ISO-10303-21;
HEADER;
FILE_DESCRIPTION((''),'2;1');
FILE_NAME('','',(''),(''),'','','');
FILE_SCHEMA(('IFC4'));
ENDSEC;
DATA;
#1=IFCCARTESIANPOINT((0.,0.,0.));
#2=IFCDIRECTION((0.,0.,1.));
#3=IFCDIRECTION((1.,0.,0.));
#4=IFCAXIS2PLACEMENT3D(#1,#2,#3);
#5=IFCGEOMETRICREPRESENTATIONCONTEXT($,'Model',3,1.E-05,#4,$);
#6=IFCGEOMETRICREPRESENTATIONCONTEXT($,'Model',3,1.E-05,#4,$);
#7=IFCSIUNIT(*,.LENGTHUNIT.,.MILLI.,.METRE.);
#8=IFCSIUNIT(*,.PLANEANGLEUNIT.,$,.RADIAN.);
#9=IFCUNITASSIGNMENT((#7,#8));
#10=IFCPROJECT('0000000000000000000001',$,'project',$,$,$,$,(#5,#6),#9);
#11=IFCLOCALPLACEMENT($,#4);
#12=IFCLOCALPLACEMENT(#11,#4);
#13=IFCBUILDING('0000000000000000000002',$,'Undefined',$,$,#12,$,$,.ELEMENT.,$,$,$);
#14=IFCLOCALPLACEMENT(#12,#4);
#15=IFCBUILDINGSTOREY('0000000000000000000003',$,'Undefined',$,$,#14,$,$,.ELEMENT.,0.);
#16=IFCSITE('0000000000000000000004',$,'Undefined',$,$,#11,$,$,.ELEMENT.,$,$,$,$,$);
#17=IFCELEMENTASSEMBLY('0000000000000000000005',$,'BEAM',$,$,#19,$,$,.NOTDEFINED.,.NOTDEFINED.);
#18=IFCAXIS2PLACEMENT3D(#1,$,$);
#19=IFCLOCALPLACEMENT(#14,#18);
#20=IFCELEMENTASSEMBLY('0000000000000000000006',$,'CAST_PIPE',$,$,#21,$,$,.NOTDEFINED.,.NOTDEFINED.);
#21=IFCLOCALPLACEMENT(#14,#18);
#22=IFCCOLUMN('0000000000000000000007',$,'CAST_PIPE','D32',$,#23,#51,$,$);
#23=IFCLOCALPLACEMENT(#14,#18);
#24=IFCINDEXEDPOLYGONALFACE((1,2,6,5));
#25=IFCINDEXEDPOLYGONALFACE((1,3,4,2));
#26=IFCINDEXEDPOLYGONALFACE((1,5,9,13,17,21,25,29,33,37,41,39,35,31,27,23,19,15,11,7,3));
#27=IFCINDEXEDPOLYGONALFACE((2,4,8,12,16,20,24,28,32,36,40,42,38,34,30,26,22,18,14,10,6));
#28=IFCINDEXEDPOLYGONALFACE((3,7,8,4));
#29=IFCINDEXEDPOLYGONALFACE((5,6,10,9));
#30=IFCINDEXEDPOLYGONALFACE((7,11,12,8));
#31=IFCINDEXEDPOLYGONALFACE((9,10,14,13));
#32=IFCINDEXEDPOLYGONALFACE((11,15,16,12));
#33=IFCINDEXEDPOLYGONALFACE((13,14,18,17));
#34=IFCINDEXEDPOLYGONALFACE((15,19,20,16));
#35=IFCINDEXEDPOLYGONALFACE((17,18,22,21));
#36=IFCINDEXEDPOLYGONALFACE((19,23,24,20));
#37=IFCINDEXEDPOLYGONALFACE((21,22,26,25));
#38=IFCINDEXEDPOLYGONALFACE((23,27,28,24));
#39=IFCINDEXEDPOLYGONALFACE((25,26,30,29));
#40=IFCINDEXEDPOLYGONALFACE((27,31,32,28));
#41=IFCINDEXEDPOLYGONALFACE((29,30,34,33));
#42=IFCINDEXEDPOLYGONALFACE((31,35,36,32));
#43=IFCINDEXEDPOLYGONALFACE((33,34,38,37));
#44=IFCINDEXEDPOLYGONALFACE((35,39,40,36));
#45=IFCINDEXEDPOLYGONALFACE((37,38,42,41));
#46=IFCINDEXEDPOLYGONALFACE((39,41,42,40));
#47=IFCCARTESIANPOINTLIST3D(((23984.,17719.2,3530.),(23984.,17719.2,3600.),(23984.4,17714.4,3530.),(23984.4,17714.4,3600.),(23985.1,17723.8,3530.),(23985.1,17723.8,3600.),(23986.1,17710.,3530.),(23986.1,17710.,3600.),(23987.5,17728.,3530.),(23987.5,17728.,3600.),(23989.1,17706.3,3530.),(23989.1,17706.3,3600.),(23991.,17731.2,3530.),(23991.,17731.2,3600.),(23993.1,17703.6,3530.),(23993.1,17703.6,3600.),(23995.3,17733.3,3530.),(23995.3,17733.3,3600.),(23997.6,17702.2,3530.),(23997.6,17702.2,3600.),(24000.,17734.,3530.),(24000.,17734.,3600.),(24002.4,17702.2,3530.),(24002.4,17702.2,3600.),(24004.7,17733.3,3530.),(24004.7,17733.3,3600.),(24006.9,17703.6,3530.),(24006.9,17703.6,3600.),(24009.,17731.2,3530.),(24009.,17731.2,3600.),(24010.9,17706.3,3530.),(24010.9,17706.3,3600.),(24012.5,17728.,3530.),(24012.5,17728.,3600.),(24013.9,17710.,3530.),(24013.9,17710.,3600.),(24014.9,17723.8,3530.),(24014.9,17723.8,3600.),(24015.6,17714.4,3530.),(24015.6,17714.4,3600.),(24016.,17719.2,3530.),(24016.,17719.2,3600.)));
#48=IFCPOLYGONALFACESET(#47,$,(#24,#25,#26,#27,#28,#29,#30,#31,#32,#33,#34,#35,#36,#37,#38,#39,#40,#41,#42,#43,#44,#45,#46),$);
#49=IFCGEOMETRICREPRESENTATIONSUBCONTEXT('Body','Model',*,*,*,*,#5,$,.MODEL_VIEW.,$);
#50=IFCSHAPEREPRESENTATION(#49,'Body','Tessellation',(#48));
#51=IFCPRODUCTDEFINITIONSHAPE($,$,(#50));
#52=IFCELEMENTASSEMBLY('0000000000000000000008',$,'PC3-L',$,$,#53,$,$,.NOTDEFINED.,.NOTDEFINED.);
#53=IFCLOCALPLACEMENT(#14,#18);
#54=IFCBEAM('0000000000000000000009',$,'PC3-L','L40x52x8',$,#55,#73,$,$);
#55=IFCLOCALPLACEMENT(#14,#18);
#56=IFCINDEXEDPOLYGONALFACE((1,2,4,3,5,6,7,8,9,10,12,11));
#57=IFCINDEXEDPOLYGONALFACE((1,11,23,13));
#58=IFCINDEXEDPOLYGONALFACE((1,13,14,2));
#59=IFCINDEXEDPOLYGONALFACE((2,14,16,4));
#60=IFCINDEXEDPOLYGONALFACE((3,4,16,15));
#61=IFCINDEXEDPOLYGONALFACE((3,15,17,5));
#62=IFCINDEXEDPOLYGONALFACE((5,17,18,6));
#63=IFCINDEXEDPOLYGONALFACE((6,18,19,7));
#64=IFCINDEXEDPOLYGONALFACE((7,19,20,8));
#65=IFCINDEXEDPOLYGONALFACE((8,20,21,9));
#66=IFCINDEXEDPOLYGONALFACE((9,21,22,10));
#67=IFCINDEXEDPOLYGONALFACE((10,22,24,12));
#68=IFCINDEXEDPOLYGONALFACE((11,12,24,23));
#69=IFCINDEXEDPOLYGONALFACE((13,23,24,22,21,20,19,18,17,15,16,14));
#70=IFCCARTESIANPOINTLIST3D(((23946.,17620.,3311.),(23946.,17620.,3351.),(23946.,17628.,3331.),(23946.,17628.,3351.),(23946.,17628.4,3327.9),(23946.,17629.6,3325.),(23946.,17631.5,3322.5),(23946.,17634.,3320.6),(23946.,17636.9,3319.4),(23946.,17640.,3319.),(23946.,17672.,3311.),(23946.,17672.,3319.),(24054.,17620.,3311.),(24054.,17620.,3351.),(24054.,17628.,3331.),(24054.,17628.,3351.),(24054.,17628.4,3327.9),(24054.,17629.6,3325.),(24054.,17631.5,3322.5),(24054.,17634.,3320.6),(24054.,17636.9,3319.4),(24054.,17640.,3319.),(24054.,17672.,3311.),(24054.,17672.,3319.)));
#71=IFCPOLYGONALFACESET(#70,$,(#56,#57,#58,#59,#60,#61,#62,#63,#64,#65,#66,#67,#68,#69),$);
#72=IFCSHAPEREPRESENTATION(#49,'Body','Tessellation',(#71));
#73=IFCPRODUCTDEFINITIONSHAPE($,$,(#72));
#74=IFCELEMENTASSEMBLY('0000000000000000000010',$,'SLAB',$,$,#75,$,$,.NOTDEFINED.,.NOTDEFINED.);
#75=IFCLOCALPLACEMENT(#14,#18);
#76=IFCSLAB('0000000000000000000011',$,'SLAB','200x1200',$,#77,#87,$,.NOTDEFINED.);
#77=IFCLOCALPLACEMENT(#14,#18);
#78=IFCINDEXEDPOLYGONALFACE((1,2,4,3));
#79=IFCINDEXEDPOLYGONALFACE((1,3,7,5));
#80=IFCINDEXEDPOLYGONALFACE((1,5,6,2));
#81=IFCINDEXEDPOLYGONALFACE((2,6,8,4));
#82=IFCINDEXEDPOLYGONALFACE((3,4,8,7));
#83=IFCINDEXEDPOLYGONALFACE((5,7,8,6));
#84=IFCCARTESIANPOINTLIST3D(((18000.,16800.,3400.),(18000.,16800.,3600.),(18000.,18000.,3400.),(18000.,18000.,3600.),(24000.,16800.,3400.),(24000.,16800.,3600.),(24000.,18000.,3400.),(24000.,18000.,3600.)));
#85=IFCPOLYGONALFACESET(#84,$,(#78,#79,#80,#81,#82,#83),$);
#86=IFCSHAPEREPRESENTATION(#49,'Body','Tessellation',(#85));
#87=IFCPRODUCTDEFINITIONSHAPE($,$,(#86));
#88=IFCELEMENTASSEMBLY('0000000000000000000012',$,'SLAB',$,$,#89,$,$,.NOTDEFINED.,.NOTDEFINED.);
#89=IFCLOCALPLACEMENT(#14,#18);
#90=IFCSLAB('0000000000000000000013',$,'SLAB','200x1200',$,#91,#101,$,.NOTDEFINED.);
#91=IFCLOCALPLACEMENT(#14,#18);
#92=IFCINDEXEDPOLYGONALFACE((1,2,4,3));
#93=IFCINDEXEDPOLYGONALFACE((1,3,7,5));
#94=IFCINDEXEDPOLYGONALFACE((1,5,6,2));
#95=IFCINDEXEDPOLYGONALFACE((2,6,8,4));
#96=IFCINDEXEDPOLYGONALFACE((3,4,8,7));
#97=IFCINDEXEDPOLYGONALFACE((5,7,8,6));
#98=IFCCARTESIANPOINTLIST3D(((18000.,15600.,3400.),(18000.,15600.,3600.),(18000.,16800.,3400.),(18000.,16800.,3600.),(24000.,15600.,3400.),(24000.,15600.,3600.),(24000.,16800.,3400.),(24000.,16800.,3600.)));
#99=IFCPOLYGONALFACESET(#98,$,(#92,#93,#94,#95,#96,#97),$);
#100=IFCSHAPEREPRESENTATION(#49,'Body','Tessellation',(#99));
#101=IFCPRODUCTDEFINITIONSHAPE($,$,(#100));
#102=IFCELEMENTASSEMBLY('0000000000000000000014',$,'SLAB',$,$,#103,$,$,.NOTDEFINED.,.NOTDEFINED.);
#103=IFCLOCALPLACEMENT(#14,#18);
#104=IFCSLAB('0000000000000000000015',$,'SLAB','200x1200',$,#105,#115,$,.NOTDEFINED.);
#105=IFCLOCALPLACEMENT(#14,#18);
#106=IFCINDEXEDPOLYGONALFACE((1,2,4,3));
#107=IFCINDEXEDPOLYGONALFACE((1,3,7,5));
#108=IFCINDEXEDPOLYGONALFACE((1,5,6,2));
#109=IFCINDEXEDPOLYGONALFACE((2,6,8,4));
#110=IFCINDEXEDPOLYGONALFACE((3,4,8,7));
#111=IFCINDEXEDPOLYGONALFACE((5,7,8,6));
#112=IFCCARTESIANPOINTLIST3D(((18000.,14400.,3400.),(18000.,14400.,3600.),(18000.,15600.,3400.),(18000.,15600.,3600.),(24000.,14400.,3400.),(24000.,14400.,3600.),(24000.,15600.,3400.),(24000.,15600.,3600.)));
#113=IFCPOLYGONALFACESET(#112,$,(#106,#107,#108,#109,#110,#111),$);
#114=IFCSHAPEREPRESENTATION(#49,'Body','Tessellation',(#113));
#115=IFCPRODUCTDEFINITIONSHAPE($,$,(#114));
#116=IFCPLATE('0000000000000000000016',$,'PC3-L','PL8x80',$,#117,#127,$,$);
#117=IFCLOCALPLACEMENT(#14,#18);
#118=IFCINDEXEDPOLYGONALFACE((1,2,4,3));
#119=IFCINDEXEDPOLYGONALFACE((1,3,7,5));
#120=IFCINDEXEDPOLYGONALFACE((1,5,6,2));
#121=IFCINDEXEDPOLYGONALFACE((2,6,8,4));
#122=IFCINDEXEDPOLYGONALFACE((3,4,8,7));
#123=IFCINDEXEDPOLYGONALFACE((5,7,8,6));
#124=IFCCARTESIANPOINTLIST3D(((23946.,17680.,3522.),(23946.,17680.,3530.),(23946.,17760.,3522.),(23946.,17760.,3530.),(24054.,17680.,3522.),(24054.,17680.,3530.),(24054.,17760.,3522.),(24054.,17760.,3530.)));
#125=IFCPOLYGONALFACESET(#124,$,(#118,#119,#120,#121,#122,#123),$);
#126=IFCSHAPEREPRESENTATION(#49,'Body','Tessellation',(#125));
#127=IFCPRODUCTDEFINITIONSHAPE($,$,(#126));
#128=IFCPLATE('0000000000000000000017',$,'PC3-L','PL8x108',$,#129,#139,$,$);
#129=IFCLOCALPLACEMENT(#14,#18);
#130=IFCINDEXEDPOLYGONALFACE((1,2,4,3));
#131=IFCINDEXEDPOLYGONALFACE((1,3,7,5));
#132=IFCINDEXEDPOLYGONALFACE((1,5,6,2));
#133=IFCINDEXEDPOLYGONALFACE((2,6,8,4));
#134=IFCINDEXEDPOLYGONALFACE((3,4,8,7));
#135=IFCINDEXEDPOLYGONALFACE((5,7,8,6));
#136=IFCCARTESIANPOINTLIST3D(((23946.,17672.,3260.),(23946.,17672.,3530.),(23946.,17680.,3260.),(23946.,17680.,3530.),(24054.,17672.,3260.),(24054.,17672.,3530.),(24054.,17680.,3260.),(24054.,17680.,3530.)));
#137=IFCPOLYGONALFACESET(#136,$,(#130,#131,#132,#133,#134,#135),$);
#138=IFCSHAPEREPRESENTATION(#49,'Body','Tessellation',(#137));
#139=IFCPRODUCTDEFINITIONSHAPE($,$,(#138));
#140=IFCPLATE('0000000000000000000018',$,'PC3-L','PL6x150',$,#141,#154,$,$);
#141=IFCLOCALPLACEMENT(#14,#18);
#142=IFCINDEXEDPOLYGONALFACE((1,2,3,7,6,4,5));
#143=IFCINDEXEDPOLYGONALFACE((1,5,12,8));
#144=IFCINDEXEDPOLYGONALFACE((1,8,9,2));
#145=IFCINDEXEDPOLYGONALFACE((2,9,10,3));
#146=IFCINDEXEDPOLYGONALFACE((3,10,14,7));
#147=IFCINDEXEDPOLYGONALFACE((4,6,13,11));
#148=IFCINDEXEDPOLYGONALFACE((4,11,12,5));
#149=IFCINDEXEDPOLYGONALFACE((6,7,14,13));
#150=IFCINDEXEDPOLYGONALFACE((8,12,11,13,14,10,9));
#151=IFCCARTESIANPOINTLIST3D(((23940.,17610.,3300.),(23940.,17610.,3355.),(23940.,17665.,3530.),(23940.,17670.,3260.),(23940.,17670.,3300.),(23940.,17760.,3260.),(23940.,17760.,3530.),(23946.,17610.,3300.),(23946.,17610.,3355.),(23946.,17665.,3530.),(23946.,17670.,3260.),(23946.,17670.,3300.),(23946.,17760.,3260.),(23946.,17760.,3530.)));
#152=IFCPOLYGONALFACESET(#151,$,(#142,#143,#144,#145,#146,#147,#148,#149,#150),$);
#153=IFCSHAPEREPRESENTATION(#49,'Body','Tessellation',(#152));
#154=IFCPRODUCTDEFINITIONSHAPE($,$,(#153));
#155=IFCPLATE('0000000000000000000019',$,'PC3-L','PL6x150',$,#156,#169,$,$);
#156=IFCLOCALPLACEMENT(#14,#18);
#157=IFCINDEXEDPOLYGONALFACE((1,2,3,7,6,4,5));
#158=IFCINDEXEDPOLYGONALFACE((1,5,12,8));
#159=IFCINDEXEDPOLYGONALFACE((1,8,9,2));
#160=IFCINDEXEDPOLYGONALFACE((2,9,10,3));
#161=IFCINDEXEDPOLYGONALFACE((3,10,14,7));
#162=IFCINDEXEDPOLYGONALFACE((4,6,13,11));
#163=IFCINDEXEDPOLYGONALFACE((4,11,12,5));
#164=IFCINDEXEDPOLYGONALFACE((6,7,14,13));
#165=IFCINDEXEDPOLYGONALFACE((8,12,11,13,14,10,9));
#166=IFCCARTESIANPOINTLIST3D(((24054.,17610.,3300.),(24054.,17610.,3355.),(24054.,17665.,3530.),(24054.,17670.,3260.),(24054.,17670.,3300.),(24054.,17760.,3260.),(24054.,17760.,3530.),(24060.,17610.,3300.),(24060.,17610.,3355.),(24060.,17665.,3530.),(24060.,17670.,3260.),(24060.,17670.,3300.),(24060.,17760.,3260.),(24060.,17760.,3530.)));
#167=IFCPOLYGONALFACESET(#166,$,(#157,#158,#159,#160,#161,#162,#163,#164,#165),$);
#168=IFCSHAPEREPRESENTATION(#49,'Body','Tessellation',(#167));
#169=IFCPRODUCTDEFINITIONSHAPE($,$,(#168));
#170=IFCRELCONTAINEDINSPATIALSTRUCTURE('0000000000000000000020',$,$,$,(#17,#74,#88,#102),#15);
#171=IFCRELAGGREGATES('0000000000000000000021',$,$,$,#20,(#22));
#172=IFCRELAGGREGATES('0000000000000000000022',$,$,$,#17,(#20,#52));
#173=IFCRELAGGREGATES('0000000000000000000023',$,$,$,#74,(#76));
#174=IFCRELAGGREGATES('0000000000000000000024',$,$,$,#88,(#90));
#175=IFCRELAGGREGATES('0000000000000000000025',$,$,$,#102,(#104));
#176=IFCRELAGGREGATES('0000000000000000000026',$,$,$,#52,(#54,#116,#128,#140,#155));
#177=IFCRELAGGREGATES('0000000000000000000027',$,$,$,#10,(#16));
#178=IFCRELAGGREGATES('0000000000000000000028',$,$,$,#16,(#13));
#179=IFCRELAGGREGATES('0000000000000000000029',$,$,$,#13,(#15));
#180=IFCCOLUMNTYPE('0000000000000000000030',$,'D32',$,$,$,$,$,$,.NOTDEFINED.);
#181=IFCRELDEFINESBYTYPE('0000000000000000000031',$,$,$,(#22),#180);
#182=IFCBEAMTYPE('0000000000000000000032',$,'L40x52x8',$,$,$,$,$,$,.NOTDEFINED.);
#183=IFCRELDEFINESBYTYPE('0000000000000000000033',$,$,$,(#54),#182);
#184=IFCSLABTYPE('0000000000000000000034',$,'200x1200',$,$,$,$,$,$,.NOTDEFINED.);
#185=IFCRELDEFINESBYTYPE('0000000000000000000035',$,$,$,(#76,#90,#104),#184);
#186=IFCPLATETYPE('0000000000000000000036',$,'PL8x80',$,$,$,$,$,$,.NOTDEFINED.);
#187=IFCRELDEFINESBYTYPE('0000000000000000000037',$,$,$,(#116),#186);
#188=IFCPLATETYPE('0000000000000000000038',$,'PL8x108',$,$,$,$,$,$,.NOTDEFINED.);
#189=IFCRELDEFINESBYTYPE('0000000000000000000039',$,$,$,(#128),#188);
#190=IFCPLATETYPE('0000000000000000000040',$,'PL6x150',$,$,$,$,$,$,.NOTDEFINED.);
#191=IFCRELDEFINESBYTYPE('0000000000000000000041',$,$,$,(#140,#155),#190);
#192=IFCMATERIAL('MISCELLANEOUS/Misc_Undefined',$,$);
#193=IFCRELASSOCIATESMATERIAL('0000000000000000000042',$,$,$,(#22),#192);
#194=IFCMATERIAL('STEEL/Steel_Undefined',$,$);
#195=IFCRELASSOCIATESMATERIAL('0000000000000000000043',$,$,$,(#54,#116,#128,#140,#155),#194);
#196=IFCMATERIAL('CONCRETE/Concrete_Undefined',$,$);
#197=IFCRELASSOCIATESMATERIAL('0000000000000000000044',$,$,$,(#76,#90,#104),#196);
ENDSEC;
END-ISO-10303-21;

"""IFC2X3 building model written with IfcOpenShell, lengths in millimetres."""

from ifc_helpers import new_model, si_unit, frame, origin_with_axes, origin_2d_with_axis, place, context, subcontext, project, spatial, polyline, circle, l_section, outline, extrude, material, type_object, element, aggregate, save


model = new_model("IFC2X3")

# Units and contexts
model_context_1 = context("Model", 3, precision=1e-05, world=origin_with_axes())
model_context_2 = context("Model", 3, precision=1e-05, world=origin_with_axes())
body_context = subcontext(model_context_1, "Body", "Model", "MODEL_VIEW")
ifc_project = project(units=[si_unit("LENGTHUNIT", "METRE", prefix="MILLI"), si_unit("PLANEANGLEUNIT", "RADIAN")], contexts=[model_context_1, model_context_2])

# Site, building, storey
site_placement = place(None, origin_with_axes())
site = spatial("IfcSite", under=ifc_project, at=site_placement, Name="Undefined", CompositionType="ELEMENT")
building_placement = place(site_placement, origin_with_axes())
building = spatial("IfcBuilding", under=site, at=building_placement, Name="Undefined", CompositionType="ELEMENT")
storey_placement = place(building_placement, origin_with_axes())
storey = spatial("IfcBuildingStorey", under=building, at=storey_placement, Name="Undefined", CompositionType="ELEMENT", Elevation=0.0)

# Element assemblies, column, beam
assembly_1_placement = place(storey_placement, origin_with_axes())
assembly_1 = element("IfcElementAssembly", 1, at=assembly_1_placement, inside=storey, Name="BEAM", AssemblyPlace="NOTDEFINED", PredefinedType="NOTDEFINED")
assembly_2_placement = place(assembly_1_placement, origin_with_axes())
assembly_2 = element("IfcElementAssembly", 2, at=assembly_2_placement, Name="CAST_PIPE", AssemblyPlace="NOTDEFINED", PredefinedType="NOTDEFINED")
ifc_material_1 = material(Name="MISCELLANEOUS/Misc_Undefined")
column_type = type_object("IfcColumnType", Name="D32", PredefinedType="NOTDEFINED")
column_placement = place(assembly_2_placement, frame((24000.0, 17718.0, 3530.0), z_axis=(0.0, 0.0, 1.0), x_axis=(1.0, 0.0, 0.0)))
column = element("IfcColumn", 3, at=column_placement, type_object=column_type, material=ifc_material_1, Name="CAST_PIPE", Description="D32", context=body_context, shape_type="SweptSolid", body=[
    extrude(circle(Radius=16.0, at=origin_2d_with_axis()), frame((0.0, 0.0, 70.0), z_axis=(0.0, 0.0, -1.0), x_axis=(0.0, 1.0, 0.0)), (0.0, 0.0, 1.0), 70.0),
])
aggregate(assembly_2, [column])
assembly_3_placement = place(assembly_1_placement, origin_with_axes())
assembly_3 = element("IfcElementAssembly", 4, at=assembly_3_placement, Name="PC3-L", AssemblyPlace="NOTDEFINED", PredefinedType="NOTDEFINED")
aggregate(assembly_1, [assembly_2, assembly_3])
ifc_material_2 = material(Name="STEEL/Steel_Undefined")
beam_type = type_object("IfcBeamType", Name="L40x52x8", PredefinedType="NOTDEFINED")
beam_placement = place(assembly_3_placement, frame((24054.0, 17646.0, 3331.0), z_axis=(0.0, 0.0, 1.0), x_axis=(-1.0, 0.0, 0.0)))
beam = element("IfcBeam", 5, at=beam_placement, type_object=beam_type, material=ifc_material_2, Name="PC3-L", Description="L40x52x8", context=body_context, shape_type="SweptSolid", body=[
    extrude(l_section(Depth=40.0, Width=52.0, Thickness=8.0, FilletRadius=12.0, at=origin_2d_with_axis()), frame((108.0, 0.0, 0.0), z_axis=(-1.0, 0.0, 0.0), x_axis=(0.0, -1.0, 0.0)), (0.0, 0.0, 1.0), 108.0),
])

# Element assemblies, slabs
assembly_4_placement = place(storey_placement, origin_with_axes())
assembly_4 = element("IfcElementAssembly", 6, at=assembly_4_placement, inside=storey, Name="SLAB", AssemblyPlace="NOTDEFINED", PredefinedType="NOTDEFINED")
ifc_material_3 = material(Name="CONCRETE/Concrete_Undefined")
slab_type = type_object("IfcSlabType", Name="200x1200", PredefinedType="NOTDEFINED")
slab_1_placement = place(assembly_4_placement, frame((24000.0, 16800.0, 3500.0), z_axis=(0.0, 0.0, 1.0), x_axis=(0.0, 1.0, 0.0)))
slab_1 = element("IfcSlab", 7, at=slab_1_placement, type_object=slab_type, material=ifc_material_3, Name="SLAB", Description="200x1200", PredefinedType="NOTDEFINED", context=body_context, shape_type="SweptSolid", body=[
    extrude(outline(polyline([(0.0, 0.0), (1200.0, 0.0), (1200.0, 6000.0), (0.0, 6000.0), (0.0, 0.0)])), frame((0.0, 0.0, -100.0), z_axis=(0.0, 0.0, 1.0), x_axis=(1.0, 0.0, 0.0)), (0.0, 0.0, 1.0), 200.0),
])
aggregate(assembly_4, [slab_1])
assembly_5_placement = place(storey_placement, origin_with_axes())
assembly_5 = element("IfcElementAssembly", 8, at=assembly_5_placement, inside=storey, Name="SLAB", AssemblyPlace="NOTDEFINED", PredefinedType="NOTDEFINED")
slab_2_placement = place(assembly_5_placement, frame((24000.0, 15600.0, 3500.0), z_axis=(0.0, 0.0, 1.0), x_axis=(0.0, 1.0, 0.0)))
slab_2 = element("IfcSlab", 9, at=slab_2_placement, type_object=slab_type, material=ifc_material_3, Name="SLAB", Description="200x1200", PredefinedType="NOTDEFINED", context=body_context, shape_type="SweptSolid", body=[
    extrude(outline(polyline([(0.0, 0.0), (1200.0, 0.0), (1200.0, 6000.0), (0.0, 6000.0), (0.0, 0.0)])), frame((0.0, 0.0, -100.0), z_axis=(0.0, 0.0, 1.0), x_axis=(1.0, 0.0, 0.0)), (0.0, 0.0, 1.0), 200.0),
])
aggregate(assembly_5, [slab_2])
assembly_6_placement = place(storey_placement, origin_with_axes())
assembly_6 = element("IfcElementAssembly", 10, at=assembly_6_placement, inside=storey, Name="SLAB", AssemblyPlace="NOTDEFINED", PredefinedType="NOTDEFINED")
slab_3_placement = place(assembly_6_placement, frame((24000.0, 14400.0, 3500.0), z_axis=(0.0, 0.0, 1.0), x_axis=(0.0, 1.0, 0.0)))
slab_3 = element("IfcSlab", 11, at=slab_3_placement, type_object=slab_type, material=ifc_material_3, Name="SLAB", Description="200x1200", PredefinedType="NOTDEFINED", context=body_context, shape_type="SweptSolid", body=[
    extrude(outline(polyline([(0.0, 0.0), (1200.0, 0.0), (1200.0, 6000.0), (0.0, 6000.0), (0.0, 0.0)])), frame((0.0, 0.0, -100.0), z_axis=(0.0, 0.0, 1.0), x_axis=(1.0, 0.0, 0.0)), (0.0, 0.0, 1.0), 200.0),
])
aggregate(assembly_6, [slab_3])

# Plates
plate_type_1 = type_object("IfcPlateType", Name="PL8x80", PredefinedType="NOTDEFINED")
plate_1_placement = place(assembly_3_placement, frame((24054.0, 17760.0, 3526.0), z_axis=(0.0, 0.0, 1.0), x_axis=(-1.0, 0.0, 0.0)))
plate_1 = element("IfcPlate", 12, at=plate_1_placement, type_object=plate_type_1, material=ifc_material_2, Name="PC3-L", Description="PL8x80", context=body_context, shape_type="SweptSolid", body=[
    extrude(outline(polyline([(0.0, 0.0), (108.0, 0.0), (108.0, 80.0), (0.0, 80.0), (0.0, 0.0)])), frame((0.0, 0.0, -4.0), z_axis=(0.0, 0.0, 1.0), x_axis=(1.0, 0.0, 0.0)), (0.0, 0.0, 1.0), 8.0),
])
plate_type_2 = type_object("IfcPlateType", Name="PL8x108", PredefinedType="NOTDEFINED")
plate_2_placement = place(assembly_3_placement, frame((24054.0, 17676.0, 3260.0), z_axis=(0.0, 1.0, 0.0), x_axis=(-1.0, 0.0, 0.0)))
plate_2 = element("IfcPlate", 13, at=plate_2_placement, type_object=plate_type_2, material=ifc_material_2, Name="PC3-L", Description="PL8x108", context=body_context, shape_type="SweptSolid", body=[
    extrude(outline(polyline([(0.0, 0.0), (108.0, 0.0), (108.0, 270.0), (0.0, 270.0), (0.0, 0.0)])), frame((0.0, 0.0, -4.0), z_axis=(0.0, 0.0, 1.0), x_axis=(1.0, 0.0, 0.0)), (0.0, 0.0, 1.0), 8.0),
])
plate_type_3 = type_object("IfcPlateType", Name="PL6x150", PredefinedType="NOTDEFINED")
plate_3_placement = place(assembly_3_placement, frame((23943.0, 17670.0, 3260.0), z_axis=(-1.0, 0.0, 0.0), x_axis=(0.0, 0.0, 1.0)))
plate_3 = element("IfcPlate", 14, at=plate_3_placement, type_object=plate_type_3, material=ifc_material_2, Name="PC3-L", Description="PL6x150", context=body_context, shape_type="SweptSolid", body=[
    extrude(outline(polyline([(0.0, 0.0), (40.0, 0.0), (40.0, -60.0), (95.0, -60.0), (270.0, -5.0), (270.0, 90.0), (0.0, 90.0), (0.0, 0.0)])), frame((0.0, 0.0, -3.0), z_axis=(0.0, 0.0, 1.0), x_axis=(1.0, 0.0, 0.0)), (0.0, 0.0, 1.0), 6.0),
])
plate_4_placement = place(assembly_3_placement, frame((24057.0, 17670.0, 3260.0), z_axis=(-1.0, 0.0, 0.0), x_axis=(0.0, 0.0, 1.0)))
plate_4 = element("IfcPlate", 15, at=plate_4_placement, type_object=plate_type_3, material=ifc_material_2, Name="PC3-L", Description="PL6x150", context=body_context, shape_type="SweptSolid", body=[
    extrude(outline(polyline([(0.0, 0.0), (40.0, 0.0), (40.0, -60.0), (95.0, -60.0), (270.0, -5.0), (270.0, 90.0), (0.0, 90.0), (0.0, 0.0)])), frame((0.0, 0.0, -3.0), z_axis=(0.0, 0.0, 1.0), x_axis=(1.0, 0.0, 0.0)), (0.0, 0.0, 1.0), 6.0),
])

aggregate(assembly_3, [beam, plate_1, plate_2, plate_3, plate_4])

save(model, "model.ifc")
